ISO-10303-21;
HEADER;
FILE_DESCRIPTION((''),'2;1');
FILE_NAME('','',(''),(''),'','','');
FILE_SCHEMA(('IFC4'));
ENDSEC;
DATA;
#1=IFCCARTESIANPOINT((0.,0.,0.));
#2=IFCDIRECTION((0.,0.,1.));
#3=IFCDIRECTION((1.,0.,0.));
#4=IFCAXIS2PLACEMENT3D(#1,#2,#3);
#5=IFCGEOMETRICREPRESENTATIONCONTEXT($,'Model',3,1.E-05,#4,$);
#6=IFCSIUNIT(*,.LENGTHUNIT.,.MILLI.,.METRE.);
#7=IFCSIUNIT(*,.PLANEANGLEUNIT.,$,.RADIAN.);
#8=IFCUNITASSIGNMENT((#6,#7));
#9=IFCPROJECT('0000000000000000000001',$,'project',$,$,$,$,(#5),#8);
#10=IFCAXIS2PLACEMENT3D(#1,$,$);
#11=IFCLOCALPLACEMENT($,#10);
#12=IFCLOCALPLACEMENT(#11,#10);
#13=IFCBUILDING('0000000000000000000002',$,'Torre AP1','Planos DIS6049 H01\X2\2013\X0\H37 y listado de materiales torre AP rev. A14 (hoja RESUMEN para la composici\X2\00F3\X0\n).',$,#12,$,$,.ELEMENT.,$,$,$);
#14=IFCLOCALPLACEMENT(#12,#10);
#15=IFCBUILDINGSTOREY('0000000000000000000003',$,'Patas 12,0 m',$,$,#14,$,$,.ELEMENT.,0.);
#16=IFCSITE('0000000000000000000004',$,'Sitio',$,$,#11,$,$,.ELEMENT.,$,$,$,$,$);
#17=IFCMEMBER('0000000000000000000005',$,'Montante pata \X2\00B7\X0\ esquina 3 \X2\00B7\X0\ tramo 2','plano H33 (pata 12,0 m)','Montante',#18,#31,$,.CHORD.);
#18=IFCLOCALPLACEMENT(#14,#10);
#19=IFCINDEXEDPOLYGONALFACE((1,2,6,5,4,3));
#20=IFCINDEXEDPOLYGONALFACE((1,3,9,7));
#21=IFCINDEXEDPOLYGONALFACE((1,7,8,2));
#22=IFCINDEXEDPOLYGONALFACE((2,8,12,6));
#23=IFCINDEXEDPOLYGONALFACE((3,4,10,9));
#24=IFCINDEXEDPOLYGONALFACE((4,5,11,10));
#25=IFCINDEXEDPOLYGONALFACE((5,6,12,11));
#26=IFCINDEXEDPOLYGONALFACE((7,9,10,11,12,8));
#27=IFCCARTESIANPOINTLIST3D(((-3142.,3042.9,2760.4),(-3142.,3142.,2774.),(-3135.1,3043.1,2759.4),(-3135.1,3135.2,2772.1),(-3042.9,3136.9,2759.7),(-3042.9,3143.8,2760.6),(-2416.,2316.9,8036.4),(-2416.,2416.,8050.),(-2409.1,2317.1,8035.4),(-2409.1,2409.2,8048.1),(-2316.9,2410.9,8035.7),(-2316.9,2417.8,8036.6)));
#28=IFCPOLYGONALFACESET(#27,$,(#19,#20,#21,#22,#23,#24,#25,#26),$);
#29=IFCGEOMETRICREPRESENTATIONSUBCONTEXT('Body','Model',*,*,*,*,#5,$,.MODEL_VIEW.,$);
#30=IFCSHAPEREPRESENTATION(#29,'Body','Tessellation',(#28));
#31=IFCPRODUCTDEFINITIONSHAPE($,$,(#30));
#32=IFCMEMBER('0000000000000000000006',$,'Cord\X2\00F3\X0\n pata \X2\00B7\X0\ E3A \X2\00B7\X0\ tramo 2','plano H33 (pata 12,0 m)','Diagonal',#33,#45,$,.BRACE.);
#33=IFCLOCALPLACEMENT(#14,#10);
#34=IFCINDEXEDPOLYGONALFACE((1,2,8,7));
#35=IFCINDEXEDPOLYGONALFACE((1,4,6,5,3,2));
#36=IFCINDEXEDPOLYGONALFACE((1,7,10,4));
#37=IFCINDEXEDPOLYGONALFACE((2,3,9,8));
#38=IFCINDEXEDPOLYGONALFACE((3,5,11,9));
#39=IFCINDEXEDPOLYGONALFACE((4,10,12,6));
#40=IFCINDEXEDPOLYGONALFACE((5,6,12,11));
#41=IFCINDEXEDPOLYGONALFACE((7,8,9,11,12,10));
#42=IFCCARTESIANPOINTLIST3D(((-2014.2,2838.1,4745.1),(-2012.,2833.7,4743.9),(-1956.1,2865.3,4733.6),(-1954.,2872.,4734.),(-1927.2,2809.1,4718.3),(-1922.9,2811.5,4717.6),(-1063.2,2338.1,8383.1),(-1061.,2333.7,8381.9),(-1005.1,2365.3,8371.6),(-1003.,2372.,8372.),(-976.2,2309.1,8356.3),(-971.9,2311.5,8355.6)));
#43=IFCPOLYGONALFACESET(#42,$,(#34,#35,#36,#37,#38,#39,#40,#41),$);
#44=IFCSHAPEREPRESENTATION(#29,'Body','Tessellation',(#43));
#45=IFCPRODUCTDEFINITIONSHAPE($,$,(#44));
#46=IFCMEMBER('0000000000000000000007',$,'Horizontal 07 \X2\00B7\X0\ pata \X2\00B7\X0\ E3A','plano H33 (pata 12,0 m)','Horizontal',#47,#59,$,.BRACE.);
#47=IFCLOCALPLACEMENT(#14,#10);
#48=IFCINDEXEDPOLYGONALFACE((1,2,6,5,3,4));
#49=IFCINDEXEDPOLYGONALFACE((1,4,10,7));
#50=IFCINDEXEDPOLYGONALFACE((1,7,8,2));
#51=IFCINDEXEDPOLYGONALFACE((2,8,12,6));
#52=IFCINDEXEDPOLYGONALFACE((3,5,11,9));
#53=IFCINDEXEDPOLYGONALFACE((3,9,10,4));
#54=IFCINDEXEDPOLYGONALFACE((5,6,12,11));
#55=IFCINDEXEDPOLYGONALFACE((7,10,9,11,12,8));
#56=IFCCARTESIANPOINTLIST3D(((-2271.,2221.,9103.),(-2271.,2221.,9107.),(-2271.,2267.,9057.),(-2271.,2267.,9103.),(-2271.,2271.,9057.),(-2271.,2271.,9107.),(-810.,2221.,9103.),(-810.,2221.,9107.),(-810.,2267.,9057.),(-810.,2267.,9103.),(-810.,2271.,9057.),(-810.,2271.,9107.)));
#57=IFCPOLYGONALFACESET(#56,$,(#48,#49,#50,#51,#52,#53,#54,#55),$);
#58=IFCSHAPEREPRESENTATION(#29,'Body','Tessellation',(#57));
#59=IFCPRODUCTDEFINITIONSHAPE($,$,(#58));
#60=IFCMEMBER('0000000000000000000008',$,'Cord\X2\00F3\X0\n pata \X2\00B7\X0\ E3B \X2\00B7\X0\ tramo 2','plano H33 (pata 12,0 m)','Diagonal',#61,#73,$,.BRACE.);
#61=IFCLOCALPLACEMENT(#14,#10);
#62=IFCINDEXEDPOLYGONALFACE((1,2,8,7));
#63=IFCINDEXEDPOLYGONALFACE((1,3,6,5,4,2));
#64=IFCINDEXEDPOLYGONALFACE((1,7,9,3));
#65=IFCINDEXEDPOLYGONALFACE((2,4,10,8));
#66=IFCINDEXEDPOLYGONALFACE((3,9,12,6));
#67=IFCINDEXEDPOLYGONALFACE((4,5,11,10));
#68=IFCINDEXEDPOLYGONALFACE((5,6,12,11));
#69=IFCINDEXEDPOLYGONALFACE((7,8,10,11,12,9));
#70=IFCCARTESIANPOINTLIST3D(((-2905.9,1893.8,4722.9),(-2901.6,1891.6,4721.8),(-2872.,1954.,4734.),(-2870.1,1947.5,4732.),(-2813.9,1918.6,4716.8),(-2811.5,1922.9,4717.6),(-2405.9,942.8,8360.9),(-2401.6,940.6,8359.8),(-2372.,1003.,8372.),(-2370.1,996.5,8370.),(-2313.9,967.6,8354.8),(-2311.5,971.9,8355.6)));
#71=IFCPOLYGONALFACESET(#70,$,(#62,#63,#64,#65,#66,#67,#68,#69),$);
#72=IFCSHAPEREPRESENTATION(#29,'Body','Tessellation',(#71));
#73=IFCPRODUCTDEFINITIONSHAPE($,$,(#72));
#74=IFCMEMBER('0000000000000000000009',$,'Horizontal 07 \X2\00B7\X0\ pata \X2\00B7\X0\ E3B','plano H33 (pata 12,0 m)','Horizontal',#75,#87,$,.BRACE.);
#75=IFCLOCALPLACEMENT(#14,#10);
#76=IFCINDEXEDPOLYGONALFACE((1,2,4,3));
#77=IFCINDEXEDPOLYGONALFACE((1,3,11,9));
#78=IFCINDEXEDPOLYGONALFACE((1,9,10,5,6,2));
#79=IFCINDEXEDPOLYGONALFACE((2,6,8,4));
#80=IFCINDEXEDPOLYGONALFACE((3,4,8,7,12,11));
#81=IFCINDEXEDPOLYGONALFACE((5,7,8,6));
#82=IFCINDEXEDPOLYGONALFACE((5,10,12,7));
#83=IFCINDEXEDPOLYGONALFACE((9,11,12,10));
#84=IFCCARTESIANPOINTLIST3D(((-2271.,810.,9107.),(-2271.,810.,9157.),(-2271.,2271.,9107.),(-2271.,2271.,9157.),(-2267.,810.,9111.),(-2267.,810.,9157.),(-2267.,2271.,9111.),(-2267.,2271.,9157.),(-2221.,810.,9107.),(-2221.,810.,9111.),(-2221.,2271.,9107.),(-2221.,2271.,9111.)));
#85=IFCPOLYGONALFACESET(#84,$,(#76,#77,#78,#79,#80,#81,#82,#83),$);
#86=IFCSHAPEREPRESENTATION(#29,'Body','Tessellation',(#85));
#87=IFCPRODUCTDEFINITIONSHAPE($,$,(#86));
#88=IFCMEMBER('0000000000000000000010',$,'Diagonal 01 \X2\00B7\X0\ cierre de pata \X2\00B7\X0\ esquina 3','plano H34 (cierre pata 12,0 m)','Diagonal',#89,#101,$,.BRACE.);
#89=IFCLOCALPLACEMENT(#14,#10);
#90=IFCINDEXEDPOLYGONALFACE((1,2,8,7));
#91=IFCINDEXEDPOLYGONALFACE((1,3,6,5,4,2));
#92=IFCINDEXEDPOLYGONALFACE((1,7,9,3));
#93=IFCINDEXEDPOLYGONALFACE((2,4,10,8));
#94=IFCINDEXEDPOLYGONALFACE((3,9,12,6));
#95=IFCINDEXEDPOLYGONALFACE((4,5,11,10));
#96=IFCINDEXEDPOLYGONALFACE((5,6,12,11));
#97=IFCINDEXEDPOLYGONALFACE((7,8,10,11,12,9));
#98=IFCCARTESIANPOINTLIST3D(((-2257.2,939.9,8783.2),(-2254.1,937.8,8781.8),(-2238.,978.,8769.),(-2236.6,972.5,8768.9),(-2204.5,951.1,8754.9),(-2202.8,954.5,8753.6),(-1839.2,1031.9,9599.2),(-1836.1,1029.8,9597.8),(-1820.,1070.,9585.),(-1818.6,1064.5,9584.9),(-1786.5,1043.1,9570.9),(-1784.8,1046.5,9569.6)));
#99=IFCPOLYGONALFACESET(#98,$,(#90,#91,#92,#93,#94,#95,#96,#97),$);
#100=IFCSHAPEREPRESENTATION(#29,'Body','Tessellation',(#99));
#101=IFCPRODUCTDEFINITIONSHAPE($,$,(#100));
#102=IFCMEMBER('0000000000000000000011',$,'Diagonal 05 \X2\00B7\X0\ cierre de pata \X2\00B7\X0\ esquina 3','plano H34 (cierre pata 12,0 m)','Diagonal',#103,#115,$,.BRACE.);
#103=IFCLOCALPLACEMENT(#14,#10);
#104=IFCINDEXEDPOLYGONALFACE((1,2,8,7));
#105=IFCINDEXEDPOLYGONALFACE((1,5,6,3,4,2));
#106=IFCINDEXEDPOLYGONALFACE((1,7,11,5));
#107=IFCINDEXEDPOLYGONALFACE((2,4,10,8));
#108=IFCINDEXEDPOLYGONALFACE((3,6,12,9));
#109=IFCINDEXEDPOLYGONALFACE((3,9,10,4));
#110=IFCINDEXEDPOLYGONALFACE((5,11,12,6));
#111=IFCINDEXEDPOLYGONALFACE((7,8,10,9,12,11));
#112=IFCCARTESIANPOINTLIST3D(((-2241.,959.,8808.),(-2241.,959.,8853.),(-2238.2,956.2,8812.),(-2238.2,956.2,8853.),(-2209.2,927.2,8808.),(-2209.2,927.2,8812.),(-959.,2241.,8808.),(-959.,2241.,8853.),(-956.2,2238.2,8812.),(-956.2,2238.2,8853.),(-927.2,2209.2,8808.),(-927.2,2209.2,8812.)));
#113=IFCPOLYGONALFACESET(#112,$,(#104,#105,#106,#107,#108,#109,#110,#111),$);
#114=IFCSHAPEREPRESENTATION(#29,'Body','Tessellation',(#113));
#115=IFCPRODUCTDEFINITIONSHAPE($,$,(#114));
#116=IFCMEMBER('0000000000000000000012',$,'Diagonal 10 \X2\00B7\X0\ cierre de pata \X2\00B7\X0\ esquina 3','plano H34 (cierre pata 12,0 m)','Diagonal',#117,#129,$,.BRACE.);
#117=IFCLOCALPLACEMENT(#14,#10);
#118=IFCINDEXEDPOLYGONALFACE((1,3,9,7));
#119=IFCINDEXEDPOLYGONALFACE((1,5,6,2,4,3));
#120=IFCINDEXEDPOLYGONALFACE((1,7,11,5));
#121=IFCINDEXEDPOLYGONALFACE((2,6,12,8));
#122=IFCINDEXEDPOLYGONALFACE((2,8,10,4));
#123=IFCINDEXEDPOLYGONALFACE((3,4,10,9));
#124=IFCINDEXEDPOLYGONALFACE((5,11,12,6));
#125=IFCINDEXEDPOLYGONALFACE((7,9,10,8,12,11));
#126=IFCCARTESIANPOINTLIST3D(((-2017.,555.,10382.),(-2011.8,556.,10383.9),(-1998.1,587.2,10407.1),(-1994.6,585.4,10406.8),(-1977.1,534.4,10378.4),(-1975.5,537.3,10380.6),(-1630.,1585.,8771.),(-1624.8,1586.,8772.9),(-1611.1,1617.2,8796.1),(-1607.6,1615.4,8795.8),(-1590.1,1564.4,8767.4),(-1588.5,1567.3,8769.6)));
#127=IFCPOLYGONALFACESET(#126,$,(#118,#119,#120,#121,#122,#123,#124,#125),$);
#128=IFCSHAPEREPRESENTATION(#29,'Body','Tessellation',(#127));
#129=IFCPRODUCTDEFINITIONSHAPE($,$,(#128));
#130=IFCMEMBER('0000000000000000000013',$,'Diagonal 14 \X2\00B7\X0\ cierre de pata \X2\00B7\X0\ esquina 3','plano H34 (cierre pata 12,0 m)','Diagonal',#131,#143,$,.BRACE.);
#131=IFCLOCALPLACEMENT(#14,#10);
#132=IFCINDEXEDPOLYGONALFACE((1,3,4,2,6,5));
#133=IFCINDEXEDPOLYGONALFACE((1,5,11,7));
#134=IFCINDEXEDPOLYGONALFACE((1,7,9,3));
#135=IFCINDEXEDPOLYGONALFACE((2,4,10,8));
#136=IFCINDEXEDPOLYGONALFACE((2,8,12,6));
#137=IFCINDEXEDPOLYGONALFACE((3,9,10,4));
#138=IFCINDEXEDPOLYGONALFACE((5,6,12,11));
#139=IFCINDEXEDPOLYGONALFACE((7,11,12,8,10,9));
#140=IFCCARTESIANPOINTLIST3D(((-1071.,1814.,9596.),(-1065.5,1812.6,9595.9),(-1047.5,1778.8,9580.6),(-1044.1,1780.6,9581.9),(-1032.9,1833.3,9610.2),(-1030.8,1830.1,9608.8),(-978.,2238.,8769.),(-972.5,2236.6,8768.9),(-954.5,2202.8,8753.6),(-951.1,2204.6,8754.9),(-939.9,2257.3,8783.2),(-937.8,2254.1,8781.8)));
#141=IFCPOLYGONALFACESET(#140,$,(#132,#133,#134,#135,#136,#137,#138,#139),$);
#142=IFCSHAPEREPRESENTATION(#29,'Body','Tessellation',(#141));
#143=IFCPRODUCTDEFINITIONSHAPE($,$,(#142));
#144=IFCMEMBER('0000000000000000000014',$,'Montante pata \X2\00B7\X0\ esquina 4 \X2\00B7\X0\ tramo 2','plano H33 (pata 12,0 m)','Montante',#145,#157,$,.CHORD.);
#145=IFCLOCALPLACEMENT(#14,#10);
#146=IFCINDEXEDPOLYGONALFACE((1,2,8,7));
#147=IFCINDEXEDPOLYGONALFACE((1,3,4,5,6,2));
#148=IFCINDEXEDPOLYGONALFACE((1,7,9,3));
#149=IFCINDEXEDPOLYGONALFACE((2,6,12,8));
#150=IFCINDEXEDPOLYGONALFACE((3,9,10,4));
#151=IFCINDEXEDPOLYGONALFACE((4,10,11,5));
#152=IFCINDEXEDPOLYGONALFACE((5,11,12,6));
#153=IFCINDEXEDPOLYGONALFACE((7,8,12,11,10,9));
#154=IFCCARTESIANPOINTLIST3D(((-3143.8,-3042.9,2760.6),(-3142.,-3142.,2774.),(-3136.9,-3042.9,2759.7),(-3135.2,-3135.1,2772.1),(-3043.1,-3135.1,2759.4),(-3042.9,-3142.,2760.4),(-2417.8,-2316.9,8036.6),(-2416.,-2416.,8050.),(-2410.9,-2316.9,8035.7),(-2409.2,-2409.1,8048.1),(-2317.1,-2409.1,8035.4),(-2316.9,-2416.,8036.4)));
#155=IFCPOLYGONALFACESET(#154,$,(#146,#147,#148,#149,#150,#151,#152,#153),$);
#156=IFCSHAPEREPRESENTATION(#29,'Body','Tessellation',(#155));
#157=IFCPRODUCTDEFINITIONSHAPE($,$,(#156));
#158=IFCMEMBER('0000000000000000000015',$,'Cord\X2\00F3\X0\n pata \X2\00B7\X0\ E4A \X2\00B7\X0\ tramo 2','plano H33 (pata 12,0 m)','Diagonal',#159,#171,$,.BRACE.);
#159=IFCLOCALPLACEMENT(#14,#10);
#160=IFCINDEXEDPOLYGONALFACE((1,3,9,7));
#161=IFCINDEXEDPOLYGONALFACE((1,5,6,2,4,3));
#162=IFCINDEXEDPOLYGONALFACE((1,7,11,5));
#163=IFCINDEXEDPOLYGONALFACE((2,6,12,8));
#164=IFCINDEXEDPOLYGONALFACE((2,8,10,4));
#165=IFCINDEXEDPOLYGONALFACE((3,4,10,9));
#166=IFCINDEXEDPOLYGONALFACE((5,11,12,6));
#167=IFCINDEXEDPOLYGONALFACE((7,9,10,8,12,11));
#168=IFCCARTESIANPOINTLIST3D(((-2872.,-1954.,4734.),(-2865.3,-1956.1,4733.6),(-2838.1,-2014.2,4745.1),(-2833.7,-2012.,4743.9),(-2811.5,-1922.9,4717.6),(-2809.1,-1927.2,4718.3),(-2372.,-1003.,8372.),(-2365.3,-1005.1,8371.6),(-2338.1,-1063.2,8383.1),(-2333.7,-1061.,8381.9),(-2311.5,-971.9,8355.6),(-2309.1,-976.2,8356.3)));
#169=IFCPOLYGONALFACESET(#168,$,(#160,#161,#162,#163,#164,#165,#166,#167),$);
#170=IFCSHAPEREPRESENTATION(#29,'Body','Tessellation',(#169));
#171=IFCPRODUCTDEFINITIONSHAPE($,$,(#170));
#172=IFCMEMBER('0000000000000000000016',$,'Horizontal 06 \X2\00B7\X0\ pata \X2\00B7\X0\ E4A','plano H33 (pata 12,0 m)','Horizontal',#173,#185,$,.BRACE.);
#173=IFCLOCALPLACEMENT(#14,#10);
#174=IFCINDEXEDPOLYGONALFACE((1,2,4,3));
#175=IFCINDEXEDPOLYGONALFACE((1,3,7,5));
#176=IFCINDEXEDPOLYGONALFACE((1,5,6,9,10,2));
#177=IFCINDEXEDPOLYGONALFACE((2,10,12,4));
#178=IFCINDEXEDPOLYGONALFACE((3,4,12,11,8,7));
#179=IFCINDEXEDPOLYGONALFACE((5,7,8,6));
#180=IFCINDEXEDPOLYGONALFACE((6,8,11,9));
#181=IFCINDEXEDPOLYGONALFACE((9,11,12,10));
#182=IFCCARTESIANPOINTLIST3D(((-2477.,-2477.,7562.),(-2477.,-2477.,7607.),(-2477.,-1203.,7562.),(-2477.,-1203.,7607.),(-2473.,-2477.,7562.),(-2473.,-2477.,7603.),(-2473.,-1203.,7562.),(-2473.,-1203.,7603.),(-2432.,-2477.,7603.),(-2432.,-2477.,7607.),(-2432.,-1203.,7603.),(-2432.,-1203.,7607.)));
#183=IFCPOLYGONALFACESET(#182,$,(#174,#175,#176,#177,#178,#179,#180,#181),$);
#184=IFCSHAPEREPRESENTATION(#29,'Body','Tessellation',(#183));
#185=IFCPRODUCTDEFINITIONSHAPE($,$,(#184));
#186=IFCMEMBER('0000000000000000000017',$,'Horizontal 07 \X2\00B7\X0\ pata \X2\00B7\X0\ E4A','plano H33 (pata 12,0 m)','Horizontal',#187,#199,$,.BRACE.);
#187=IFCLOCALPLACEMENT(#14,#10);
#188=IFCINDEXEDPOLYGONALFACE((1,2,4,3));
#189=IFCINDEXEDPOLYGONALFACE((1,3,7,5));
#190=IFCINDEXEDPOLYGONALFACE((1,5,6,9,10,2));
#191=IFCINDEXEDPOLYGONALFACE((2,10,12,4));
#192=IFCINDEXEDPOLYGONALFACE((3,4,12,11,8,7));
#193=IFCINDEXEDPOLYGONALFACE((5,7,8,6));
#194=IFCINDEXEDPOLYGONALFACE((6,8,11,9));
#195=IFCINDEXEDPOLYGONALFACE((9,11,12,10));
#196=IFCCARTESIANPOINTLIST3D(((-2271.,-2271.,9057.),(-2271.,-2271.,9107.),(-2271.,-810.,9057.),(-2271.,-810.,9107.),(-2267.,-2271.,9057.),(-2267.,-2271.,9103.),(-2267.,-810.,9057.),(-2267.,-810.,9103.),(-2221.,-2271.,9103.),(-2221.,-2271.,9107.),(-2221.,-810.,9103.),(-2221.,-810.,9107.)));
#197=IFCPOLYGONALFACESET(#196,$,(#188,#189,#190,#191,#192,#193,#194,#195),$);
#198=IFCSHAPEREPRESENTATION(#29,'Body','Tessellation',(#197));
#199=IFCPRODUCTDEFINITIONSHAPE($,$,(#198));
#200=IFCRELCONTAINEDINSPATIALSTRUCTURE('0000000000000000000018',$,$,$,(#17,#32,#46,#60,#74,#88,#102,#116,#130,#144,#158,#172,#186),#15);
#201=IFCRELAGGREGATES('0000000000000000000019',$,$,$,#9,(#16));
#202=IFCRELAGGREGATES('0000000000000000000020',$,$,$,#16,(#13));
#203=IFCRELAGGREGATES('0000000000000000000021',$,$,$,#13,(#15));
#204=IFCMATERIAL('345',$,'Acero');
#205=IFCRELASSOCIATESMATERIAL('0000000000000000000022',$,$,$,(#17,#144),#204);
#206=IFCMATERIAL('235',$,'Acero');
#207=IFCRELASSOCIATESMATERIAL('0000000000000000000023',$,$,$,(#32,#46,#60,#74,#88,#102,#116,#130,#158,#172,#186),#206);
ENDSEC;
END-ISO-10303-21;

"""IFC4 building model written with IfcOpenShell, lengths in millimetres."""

from ifc_helpers import new_model, si_unit, frame, frame_2d, origin, origin_with_axes, place, context, subcontext, project, spatial, l_section, extrude, material, element, save


model = new_model("IFC4")

# Units and contexts
model_context = context("Model", 3, precision=1e-05, world=origin_with_axes())
body_context = subcontext(model_context, "Body", "Model", "MODEL_VIEW")
ifc_project = project(units=[si_unit("LENGTHUNIT", "METRE", prefix="MILLI"), si_unit("PLANEANGLEUNIT", "RADIAN")], contexts=[model_context])

# Site, building, storey
site_placement = place(None, origin())
site = spatial("IfcSite", under=ifc_project, at=site_placement, Name="Sitio", CompositionType="ELEMENT")
building_placement = place(site_placement, origin())
building = spatial("IfcBuilding", under=site, at=building_placement, Name="Torre AP1", Description="Planos DIS6049 H01–H37 y listado de materiales torre AP rev. A14 (hoja RESUMEN para la composición).", CompositionType="ELEMENT")
storey_placement = place(building_placement, origin())
storey = spatial("IfcBuildingStorey", under=building, at=storey_placement, Name="Patas 12,0 m", CompositionType="ELEMENT", Elevation=0.0)

# Members
ifc_material_1 = material(Name="345", Category="Acero")
member_1_placement = place(storey_placement, frame((-2416.0, 2416.0, 8050.0), z_axis=(-0.13507, 0.13507, -0.981586), x_axis=(0.990836, 0.018413, -0.13381)))
element("IfcMember", 1, at=member_1_placement, inside=storey, material=ifc_material_1, Name="Montante pata · esquina 3 · tramo 2", Description="plano H33 (pata 12,0 m)", ObjectType="Montante", PredefinedType="CHORD", context=body_context, shape_type="SweptSolid", body=[
    extrude(l_section(Depth=100.0, Width=100.0, Thickness=7.0, at=frame_2d((50.0, 50.0))), None, (0.0, 0.0, 1.0), 5375.0),
])
ifc_material_2 = material(Name="235", Category="Acero")
member_2_placement = place(storey_placement, frame((-1003.0, 2372.0, 8372.0), z_axis=(-0.250702, 0.13181, -0.959049), x_axis=(0.444282, -0.864528, -0.234958)))
element("IfcMember", 2, at=member_2_placement, inside=storey, material=ifc_material_2, Name="Cordón pata · E3A · tramo 2", Description="plano H33 (pata 12,0 m)", ObjectType="Diagonal", PredefinedType="BRACE", context=body_context, shape_type="SweptSolid", body=[
    extrude(l_section(Depth=70.0, Width=70.0, Thickness=5.0, at=frame_2d((35.0, 35.0))), None, (0.0, 0.0, 1.0), 3793.3),
])
member_3_placement = place(storey_placement, frame((-2271.0, 2271.0, 9107.0), z_axis=(1.0, 0.0, 0.0), x_axis=(0.0, -1.0, 0.0)))
element("IfcMember", 3, at=member_3_placement, inside=storey, material=ifc_material_2, Name="Horizontal 07 · pata · E3A", Description="plano H33 (pata 12,0 m)", ObjectType="Horizontal", PredefinedType="BRACE", context=body_context, shape_type="SweptSolid", body=[
    extrude(l_section(Depth=50.0, Width=50.0, Thickness=4.0, at=frame_2d((25.0, 25.0))), None, (0.0, 0.0, 1.0), 1461.0),
])
member_4_placement = place(storey_placement, frame((-2372.0, 1003.0, 8372.0), z_axis=(-0.13181, 0.250702, -0.959049), x_axis=(0.864528, -0.444282, -0.234958)))
element("IfcMember", 4, at=member_4_placement, inside=storey, material=ifc_material_2, Name="Cordón pata · E3B · tramo 2", Description="plano H33 (pata 12,0 m)", ObjectType="Diagonal", PredefinedType="BRACE", context=body_context, shape_type="SweptSolid", body=[
    extrude(l_section(Depth=70.0, Width=70.0, Thickness=5.0, at=frame_2d((35.0, 35.0))), None, (0.0, 0.0, 1.0), 3793.3),
])
member_5_placement = place(storey_placement, frame((-2271.0, 2271.0, 9107.0), z_axis=(0.0, -1.0, 0.0), x_axis=(1.0, 0.0, 0.0)))
element("IfcMember", 5, at=member_5_placement, inside=storey, material=ifc_material_2, Name="Horizontal 07 · pata · E3B", Description="plano H33 (pata 12,0 m)", ObjectType="Horizontal", PredefinedType="BRACE", context=body_context, shape_type="SweptSolid", body=[
    extrude(l_section(Depth=50.0, Width=50.0, Thickness=4.0, at=frame_2d((25.0, 25.0))), None, (0.0, 0.0, 1.0), 1461.0),
])
member_6_placement = place(storey_placement, frame((-1820.0, 1070.0, 9585.0), z_axis=(-0.45364, -0.099844, -0.885574), x_axis=(0.78186, -0.521462, -0.34172)))
element("IfcMember", 6, at=member_6_placement, inside=storey, material=ifc_material_2, Name="Diagonal 01 · cierre de pata · esquina 3", Description="plano H34 (cierre pata 12,0 m)", ObjectType="Diagonal", PredefinedType="BRACE", context=body_context, shape_type="SweptSolid", body=[
    extrude(l_section(Depth=45.0, Width=45.0, Thickness=4.0, at=frame_2d((22.5, 22.5))), None, (0.0, 0.0, 1.0), 921.4),
])
member_7_placement = place(storey_placement, frame((-959.0, 2241.0, 8808.0), z_axis=(-0.707107, -0.707107, 0.0), x_axis=(0.707107, -0.707107, 0.0)))
element("IfcMember", 7, at=member_7_placement, inside=storey, material=ifc_material_2, Name="Diagonal 05 · cierre de pata · esquina 3", Description="plano H34 (cierre pata 12,0 m)", ObjectType="Diagonal", PredefinedType="BRACE", context=body_context, shape_type="SweptSolid", body=[
    extrude(l_section(Depth=45.0, Width=45.0, Thickness=4.0, at=frame_2d((22.5, 22.5))), None, (0.0, 0.0, 1.0), 1813.0),
])
member_8_placement = place(storey_placement, frame((-1630.0, 1585.0, 8771.0), z_axis=(-0.198371, -0.527963, 0.825775), x_axis=(0.885645, -0.457467, -0.079731)))
element("IfcMember", 8, at=member_8_placement, inside=storey, material=ifc_material_2, Name="Diagonal 10 · cierre de pata · esquina 3", Description="plano H34 (cierre pata 12,0 m)", ObjectType="Diagonal", PredefinedType="BRACE", context=body_context, shape_type="SweptSolid", body=[
    extrude(l_section(Depth=45.0, Width=45.0, Thickness=4.0, at=frame_2d((22.5, 22.5))), None, (0.0, 0.0, 1.0), 1950.9),
])
member_9_placement = place(storey_placement, frame((-978.0, 2238.0, 8769.0), z_axis=(-0.099572, -0.453962, 0.88544), x_axis=(0.522172, -0.781324, -0.341862)))
element("IfcMember", 9, at=member_9_placement, inside=storey, material=ifc_material_2, Name="Diagonal 14 · cierre de pata · esquina 3", Description="plano H34 (cierre pata 12,0 m)", ObjectType="Diagonal", PredefinedType="BRACE", context=body_context, shape_type="SweptSolid", body=[
    extrude(l_section(Depth=45.0, Width=45.0, Thickness=4.0, at=frame_2d((22.5, 22.5))), None, (0.0, 0.0, 1.0), 934.0),
])
member_10_placement = place(storey_placement, frame((-2416.0, -2416.0, 8050.0), z_axis=(-0.13507, -0.13507, -0.981586), x_axis=(-0.018413, 0.990836, -0.13381)))
element("IfcMember", 10, at=member_10_placement, inside=storey, material=ifc_material_1, Name="Montante pata · esquina 4 · tramo 2", Description="plano H33 (pata 12,0 m)", ObjectType="Montante", PredefinedType="CHORD", context=body_context, shape_type="SweptSolid", body=[
    extrude(l_section(Depth=100.0, Width=100.0, Thickness=7.0, at=frame_2d((50.0, 50.0))), None, (0.0, 0.0, 1.0), 5375.0),
])
member_11_placement = place(storey_placement, frame((-2372.0, -1003.0, 8372.0), z_axis=(-0.13181, -0.250702, -0.959049), x_axis=(0.864528, 0.444282, -0.234958)))
element("IfcMember", 11, at=member_11_placement, inside=storey, material=ifc_material_2, Name="Cordón pata · E4A · tramo 2", Description="plano H33 (pata 12,0 m)", ObjectType="Diagonal", PredefinedType="BRACE", context=body_context, shape_type="SweptSolid", body=[
    extrude(l_section(Depth=70.0, Width=70.0, Thickness=5.0, at=frame_2d((35.0, 35.0))), None, (0.0, 0.0, 1.0), 3793.3),
])
member_12_placement = place(storey_placement, frame((-2477.0, -2477.0, 7607.0), z_axis=(0.0, 1.0, 0.0), x_axis=(1.0, 0.0, 0.0)))
element("IfcMember", 12, at=member_12_placement, inside=storey, material=ifc_material_2, Name="Horizontal 06 · pata · E4A", Description="plano H33 (pata 12,0 m)", ObjectType="Horizontal", PredefinedType="BRACE", context=body_context, shape_type="SweptSolid", body=[
    extrude(l_section(Depth=45.0, Width=45.0, Thickness=4.0, at=frame_2d((22.5, 22.5))), None, (0.0, 0.0, 1.0), 1274.0),
])
member_13_placement = place(storey_placement, frame((-2271.0, -2271.0, 9107.0), z_axis=(0.0, 1.0, 0.0), x_axis=(1.0, 0.0, 0.0)))
element("IfcMember", 13, at=member_13_placement, inside=storey, material=ifc_material_2, Name="Horizontal 07 · pata · E4A", Description="plano H33 (pata 12,0 m)", ObjectType="Horizontal", PredefinedType="BRACE", context=body_context, shape_type="SweptSolid", body=[
    extrude(l_section(Depth=50.0, Width=50.0, Thickness=4.0, at=frame_2d((25.0, 25.0))), None, (0.0, 0.0, 1.0), 1461.0),
])

save(model, "model.ifc")
